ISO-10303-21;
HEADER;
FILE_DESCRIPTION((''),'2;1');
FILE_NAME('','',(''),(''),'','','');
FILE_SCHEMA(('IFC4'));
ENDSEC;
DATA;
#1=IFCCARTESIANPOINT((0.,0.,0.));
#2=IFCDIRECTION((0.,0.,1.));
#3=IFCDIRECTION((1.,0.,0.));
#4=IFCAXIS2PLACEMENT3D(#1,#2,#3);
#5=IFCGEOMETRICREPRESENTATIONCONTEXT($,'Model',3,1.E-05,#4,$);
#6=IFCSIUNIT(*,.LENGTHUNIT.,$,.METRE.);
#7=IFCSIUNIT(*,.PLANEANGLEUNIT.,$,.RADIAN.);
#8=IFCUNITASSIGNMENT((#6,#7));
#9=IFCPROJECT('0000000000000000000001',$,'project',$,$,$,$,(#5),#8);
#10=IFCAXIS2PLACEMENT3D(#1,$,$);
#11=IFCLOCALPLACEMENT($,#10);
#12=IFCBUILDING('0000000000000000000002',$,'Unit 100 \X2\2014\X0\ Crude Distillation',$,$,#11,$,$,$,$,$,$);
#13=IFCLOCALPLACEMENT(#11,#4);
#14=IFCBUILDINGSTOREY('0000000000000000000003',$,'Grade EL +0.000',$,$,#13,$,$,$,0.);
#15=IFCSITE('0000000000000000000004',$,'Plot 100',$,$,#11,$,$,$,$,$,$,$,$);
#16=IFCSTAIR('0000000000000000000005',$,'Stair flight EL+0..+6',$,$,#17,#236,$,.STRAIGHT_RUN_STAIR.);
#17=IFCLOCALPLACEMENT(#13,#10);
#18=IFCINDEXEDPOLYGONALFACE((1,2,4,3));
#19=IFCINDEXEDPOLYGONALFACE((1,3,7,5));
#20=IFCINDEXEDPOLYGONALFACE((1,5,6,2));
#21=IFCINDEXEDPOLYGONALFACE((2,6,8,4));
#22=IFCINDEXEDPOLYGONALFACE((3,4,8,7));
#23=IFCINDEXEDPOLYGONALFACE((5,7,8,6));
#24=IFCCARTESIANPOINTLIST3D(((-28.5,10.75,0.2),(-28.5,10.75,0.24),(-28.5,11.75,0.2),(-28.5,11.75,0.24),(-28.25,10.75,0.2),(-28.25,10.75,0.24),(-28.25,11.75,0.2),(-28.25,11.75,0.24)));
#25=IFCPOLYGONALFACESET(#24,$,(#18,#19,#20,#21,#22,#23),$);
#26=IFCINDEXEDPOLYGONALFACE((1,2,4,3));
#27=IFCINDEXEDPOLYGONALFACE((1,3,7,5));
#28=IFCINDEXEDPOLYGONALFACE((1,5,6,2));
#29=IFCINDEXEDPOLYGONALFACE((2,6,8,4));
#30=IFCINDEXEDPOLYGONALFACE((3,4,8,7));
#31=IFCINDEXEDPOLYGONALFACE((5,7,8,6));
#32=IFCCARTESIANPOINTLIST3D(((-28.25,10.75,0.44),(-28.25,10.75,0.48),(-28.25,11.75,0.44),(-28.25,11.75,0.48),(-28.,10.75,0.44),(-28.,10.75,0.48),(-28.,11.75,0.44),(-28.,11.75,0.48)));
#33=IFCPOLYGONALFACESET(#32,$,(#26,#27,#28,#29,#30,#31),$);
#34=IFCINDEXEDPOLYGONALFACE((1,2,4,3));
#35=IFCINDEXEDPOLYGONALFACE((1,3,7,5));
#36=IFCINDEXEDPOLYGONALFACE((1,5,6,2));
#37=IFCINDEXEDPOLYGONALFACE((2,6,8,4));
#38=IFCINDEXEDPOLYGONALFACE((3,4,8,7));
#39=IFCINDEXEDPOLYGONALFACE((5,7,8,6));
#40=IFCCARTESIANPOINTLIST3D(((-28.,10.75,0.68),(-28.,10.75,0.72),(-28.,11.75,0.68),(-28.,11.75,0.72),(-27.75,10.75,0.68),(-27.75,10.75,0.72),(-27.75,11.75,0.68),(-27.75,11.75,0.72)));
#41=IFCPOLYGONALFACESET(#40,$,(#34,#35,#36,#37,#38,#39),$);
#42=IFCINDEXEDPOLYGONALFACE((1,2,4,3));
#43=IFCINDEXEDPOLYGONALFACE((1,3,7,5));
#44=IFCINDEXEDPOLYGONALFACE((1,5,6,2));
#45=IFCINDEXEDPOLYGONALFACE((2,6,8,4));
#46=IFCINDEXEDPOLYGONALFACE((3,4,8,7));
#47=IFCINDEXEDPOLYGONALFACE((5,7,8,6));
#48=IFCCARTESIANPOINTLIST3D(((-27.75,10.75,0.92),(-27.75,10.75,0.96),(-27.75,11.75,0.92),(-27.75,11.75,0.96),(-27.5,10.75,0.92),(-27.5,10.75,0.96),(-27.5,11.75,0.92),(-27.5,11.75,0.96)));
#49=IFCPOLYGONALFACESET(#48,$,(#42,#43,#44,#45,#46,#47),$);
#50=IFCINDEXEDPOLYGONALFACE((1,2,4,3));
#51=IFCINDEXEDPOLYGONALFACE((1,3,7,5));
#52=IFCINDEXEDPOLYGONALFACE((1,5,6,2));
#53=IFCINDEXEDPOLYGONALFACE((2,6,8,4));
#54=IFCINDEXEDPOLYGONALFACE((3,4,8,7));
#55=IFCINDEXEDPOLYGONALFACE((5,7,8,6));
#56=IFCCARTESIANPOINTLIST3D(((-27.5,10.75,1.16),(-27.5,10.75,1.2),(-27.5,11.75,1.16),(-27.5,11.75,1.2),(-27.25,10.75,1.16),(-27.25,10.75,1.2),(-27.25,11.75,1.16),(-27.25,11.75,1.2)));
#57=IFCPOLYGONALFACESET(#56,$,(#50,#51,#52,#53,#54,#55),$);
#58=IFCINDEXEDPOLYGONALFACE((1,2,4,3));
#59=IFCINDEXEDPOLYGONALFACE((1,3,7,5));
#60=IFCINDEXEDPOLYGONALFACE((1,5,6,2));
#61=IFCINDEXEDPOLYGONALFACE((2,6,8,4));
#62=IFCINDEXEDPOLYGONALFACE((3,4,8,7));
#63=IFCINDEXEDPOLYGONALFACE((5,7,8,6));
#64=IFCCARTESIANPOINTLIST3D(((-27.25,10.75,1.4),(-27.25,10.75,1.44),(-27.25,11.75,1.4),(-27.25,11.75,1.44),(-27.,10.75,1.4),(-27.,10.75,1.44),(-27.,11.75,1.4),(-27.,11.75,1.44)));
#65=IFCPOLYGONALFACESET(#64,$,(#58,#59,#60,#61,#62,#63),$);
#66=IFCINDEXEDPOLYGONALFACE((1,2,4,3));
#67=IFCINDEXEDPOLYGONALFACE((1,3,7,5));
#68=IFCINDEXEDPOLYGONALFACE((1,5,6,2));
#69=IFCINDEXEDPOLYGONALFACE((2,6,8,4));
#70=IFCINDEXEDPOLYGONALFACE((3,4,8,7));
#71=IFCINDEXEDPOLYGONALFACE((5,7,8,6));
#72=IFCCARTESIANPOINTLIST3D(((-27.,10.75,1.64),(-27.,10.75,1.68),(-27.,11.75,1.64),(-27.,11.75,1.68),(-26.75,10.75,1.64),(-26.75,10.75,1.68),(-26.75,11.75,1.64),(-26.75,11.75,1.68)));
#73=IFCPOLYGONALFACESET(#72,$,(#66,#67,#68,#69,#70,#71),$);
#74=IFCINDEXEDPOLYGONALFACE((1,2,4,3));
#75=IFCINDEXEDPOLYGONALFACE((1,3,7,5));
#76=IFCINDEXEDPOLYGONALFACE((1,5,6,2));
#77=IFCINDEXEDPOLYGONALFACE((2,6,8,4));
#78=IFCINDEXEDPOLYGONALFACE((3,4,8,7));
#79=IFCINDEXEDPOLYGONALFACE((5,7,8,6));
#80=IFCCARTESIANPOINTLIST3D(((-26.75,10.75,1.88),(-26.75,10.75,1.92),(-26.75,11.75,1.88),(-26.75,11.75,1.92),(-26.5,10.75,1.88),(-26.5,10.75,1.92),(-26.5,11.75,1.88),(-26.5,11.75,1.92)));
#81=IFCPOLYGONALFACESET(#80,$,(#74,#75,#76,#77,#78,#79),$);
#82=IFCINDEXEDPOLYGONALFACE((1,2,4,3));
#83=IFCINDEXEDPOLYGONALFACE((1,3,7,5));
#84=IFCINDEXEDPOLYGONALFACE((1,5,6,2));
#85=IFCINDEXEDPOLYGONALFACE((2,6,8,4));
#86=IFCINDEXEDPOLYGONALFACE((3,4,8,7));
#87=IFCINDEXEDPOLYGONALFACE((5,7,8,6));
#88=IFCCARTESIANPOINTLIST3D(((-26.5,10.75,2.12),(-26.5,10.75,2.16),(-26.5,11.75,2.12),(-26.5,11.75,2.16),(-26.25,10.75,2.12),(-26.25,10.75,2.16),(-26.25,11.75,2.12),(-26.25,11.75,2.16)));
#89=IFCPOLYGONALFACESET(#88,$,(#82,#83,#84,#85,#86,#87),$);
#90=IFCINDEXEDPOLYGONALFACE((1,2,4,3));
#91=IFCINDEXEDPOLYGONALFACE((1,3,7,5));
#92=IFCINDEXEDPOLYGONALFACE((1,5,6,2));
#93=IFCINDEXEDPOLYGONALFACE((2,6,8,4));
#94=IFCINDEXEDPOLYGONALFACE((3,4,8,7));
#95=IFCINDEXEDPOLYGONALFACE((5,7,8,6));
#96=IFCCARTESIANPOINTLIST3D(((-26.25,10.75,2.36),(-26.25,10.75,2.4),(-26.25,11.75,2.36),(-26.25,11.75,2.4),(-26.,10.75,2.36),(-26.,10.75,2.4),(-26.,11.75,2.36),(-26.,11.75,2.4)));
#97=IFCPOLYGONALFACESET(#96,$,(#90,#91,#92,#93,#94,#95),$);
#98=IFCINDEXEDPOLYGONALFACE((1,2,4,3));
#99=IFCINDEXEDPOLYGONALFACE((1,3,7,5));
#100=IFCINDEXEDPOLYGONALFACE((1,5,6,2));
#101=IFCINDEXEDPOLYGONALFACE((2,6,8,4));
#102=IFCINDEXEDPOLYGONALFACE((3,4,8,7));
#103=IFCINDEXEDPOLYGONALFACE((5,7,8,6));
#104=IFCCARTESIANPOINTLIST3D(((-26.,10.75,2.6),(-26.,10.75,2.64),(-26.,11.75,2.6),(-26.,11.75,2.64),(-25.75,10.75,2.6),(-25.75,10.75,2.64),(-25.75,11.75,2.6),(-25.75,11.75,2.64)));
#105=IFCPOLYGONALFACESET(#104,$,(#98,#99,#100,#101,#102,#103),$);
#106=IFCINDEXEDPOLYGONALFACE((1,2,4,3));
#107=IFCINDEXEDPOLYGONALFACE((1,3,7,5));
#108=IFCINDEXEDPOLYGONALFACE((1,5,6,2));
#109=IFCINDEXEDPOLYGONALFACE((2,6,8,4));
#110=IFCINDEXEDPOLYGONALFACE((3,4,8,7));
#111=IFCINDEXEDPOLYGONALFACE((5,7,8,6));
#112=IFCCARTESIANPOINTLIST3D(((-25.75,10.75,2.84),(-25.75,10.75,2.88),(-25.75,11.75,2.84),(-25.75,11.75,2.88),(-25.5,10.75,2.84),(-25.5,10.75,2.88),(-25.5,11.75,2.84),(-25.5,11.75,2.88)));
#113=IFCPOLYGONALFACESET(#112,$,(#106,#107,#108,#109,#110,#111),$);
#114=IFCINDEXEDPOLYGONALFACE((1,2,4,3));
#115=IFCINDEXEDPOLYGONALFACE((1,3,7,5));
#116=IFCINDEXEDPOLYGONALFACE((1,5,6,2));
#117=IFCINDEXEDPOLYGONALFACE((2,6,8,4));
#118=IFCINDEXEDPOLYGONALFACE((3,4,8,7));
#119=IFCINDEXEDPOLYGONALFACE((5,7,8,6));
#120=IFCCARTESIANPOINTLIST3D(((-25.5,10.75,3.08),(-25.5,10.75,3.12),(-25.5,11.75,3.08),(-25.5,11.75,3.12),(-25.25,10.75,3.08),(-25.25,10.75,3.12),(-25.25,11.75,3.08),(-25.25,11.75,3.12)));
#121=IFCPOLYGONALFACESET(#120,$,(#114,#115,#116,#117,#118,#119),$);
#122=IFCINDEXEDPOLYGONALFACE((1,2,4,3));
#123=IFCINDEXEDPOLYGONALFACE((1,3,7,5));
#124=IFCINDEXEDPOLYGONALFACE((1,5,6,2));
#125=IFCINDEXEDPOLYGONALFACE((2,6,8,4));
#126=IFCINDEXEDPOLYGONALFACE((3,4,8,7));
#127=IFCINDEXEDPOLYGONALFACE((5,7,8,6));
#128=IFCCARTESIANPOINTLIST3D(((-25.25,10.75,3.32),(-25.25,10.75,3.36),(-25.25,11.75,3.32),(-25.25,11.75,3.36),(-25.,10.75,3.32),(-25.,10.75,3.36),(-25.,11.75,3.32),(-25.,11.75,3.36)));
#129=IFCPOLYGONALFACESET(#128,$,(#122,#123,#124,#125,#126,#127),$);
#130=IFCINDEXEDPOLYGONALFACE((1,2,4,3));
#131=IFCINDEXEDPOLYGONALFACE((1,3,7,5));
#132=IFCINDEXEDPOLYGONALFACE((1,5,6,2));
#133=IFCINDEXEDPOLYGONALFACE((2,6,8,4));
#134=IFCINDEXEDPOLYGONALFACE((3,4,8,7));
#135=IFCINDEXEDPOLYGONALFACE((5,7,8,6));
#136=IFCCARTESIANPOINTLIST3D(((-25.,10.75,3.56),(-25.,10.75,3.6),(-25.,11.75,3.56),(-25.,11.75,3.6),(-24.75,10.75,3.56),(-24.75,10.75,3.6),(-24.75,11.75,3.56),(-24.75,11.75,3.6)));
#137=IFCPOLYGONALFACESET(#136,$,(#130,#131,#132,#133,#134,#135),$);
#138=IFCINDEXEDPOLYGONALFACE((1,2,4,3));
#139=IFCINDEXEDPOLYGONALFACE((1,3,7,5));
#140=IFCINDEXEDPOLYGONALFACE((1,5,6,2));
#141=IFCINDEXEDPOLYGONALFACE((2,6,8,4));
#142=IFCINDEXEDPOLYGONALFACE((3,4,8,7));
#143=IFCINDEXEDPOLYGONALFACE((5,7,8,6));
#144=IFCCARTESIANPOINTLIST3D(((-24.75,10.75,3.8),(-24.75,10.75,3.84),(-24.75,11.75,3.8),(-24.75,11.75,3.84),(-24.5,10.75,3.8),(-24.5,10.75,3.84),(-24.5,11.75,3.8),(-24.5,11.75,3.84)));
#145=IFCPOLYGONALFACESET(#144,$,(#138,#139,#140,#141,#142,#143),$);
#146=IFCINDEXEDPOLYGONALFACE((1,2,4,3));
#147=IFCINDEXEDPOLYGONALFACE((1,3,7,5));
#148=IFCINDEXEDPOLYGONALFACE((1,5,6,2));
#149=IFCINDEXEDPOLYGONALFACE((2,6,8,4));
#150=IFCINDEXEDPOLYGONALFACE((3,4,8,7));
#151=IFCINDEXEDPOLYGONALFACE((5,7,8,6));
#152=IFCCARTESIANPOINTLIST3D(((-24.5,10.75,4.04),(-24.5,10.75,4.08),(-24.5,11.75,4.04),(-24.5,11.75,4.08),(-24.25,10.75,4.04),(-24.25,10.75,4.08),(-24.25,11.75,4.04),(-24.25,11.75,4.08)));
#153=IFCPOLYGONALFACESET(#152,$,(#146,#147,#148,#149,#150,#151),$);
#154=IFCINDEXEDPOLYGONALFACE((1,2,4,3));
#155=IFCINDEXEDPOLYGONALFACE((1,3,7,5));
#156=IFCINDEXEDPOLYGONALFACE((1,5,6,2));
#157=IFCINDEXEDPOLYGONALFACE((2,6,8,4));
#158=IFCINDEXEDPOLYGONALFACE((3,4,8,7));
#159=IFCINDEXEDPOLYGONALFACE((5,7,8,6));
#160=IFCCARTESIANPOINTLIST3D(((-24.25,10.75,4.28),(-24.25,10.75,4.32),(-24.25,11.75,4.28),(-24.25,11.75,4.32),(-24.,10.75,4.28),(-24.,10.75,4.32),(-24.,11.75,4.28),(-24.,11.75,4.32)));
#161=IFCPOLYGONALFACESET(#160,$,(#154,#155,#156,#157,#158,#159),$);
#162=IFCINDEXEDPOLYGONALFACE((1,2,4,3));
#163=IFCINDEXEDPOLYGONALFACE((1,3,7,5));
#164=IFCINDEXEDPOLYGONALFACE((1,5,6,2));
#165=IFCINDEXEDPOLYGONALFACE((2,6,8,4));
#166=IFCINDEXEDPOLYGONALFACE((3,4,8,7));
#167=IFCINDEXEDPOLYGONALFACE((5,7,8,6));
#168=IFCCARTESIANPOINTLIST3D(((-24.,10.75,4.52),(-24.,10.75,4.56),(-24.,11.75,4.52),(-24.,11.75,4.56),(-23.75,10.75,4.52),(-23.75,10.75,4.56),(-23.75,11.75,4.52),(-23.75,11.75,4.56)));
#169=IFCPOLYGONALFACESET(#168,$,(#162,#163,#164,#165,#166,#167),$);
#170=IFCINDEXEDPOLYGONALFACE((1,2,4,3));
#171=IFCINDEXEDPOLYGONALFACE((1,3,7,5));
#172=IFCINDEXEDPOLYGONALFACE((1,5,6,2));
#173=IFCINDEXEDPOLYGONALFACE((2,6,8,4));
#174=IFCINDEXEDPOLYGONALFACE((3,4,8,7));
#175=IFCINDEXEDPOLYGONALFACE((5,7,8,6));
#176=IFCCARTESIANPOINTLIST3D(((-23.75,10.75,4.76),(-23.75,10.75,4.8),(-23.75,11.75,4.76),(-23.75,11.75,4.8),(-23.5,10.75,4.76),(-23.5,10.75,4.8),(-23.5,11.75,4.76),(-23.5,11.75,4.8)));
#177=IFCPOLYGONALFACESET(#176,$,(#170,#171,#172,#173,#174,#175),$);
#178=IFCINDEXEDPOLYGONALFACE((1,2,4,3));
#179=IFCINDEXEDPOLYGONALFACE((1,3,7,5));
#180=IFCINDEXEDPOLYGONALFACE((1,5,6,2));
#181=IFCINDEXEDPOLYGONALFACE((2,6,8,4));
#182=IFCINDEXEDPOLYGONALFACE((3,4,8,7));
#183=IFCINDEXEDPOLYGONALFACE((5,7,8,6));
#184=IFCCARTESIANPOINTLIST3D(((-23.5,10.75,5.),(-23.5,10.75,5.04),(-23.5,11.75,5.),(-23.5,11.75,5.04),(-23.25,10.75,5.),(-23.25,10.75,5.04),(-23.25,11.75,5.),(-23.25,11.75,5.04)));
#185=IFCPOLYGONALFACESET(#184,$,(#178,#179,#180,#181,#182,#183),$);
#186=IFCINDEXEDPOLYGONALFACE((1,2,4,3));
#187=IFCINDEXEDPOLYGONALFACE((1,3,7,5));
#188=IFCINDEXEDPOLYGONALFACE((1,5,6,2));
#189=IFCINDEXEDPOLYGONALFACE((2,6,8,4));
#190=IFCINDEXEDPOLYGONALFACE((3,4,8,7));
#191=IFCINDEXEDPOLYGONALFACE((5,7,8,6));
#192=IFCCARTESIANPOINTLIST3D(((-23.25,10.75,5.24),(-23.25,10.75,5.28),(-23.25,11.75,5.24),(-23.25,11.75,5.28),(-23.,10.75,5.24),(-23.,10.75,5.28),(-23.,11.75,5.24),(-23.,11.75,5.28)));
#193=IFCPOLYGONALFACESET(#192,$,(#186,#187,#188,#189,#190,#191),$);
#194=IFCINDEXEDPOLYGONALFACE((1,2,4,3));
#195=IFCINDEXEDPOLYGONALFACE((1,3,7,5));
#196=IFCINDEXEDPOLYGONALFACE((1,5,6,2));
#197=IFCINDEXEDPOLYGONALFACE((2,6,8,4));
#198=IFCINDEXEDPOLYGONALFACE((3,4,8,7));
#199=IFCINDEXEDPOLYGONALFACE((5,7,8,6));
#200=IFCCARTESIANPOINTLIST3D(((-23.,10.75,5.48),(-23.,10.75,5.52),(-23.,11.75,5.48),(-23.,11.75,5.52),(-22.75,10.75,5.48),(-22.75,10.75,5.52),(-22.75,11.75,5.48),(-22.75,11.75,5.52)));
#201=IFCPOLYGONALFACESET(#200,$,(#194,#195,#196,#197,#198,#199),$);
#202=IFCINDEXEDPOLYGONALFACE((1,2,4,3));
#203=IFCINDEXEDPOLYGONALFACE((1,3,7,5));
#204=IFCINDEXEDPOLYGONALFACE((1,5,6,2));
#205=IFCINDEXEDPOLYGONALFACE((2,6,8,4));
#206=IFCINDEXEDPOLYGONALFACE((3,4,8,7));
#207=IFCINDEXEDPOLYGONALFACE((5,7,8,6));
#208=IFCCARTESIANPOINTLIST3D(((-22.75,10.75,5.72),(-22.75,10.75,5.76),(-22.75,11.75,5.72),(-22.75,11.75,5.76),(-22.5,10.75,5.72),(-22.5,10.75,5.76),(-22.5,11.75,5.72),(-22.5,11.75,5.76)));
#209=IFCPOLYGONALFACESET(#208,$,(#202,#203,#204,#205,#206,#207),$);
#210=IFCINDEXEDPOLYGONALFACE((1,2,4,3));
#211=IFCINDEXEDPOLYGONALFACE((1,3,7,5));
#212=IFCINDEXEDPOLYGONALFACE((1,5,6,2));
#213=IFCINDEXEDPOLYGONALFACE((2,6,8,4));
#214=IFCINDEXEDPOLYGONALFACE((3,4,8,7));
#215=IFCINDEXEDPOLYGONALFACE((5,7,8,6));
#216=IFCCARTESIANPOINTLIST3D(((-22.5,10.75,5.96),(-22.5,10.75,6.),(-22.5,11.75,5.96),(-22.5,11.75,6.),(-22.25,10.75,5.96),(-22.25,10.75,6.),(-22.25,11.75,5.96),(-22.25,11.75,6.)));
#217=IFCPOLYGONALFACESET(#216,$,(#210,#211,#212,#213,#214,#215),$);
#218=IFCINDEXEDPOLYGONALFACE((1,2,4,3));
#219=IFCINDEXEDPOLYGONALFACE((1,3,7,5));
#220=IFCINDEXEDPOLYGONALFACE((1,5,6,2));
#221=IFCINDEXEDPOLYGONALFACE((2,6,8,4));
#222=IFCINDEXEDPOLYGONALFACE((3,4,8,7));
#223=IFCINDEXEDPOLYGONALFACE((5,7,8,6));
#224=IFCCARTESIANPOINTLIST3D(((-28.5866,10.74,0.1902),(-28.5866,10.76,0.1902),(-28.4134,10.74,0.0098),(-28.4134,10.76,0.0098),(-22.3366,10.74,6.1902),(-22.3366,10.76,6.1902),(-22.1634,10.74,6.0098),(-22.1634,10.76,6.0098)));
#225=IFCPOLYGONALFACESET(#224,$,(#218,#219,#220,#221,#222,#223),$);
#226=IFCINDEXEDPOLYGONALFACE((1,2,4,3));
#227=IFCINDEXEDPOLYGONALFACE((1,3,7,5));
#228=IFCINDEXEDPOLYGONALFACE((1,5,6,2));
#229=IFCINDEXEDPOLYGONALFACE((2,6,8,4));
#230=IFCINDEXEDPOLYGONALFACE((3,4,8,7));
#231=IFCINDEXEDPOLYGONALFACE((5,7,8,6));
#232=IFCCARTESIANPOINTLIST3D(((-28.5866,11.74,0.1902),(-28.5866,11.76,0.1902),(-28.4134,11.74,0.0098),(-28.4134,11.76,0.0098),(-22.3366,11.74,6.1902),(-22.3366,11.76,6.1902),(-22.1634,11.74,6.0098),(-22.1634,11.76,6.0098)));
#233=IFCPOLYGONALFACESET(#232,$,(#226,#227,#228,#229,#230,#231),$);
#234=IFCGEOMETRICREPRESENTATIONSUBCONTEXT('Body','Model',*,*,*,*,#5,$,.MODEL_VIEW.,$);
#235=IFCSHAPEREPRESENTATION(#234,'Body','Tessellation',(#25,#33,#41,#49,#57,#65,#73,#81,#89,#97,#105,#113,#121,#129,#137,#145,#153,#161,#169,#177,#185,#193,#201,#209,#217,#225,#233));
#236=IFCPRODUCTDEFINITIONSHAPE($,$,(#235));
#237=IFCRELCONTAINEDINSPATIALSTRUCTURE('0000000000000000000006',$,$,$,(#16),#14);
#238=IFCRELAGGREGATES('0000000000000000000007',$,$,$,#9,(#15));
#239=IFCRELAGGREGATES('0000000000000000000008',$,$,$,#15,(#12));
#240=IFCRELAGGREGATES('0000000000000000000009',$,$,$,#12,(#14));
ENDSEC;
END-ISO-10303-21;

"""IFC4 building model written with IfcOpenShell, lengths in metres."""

from ifc_helpers import new_model, si_unit, frame, origin, origin_with_axes, origin_2d, place, context, subcontext, project, spatial, rectangle, extrude, element, save


model = new_model("IFC4")

# Units and contexts
model_context = context("Model", 3, precision=1e-05, world=origin_with_axes())
body_context = subcontext(model_context, "Body", "Model", "MODEL_VIEW")
ifc_project = project(units=[si_unit("LENGTHUNIT", "METRE"), si_unit("PLANEANGLEUNIT", "RADIAN")], contexts=[model_context])

# Site, building, storey
placement = place(None, origin())
site = spatial("IfcSite", under=ifc_project, at=placement, Name="Plot 100")
building = spatial("IfcBuilding", under=site, at=placement, Name="Unit 100 — Crude Distillation")
storey_placement = place(placement, origin_with_axes())
storey = spatial("IfcBuildingStorey", under=building, at=storey_placement, Name="Grade EL +0.000", Elevation=0.0)

# Stair
stair_placement = place(storey_placement, origin_with_axes())
element("IfcStair", 1, at=stair_placement, inside=storey, Name="Stair flight EL+0..+6", PredefinedType="STRAIGHT_RUN_STAIR", context=body_context, shape_type="SweptSolid", body=[
    extrude(rectangle(XDim=0.25, YDim=1.0, at=origin_2d()), frame((-28.375, 11.25, 0.2), z_axis=(0.0, 0.0, 1.0), x_axis=(1.0, 0.0, 0.0)), (0.0, 0.0, 1.0), 0.04),
    extrude(rectangle(XDim=0.25, YDim=1.0, at=origin_2d()), frame((-28.125, 11.25, 0.44), z_axis=(0.0, 0.0, 1.0), x_axis=(1.0, 0.0, 0.0)), (0.0, 0.0, 1.0), 0.04),
    extrude(rectangle(XDim=0.25, YDim=1.0, at=origin_2d()), frame((-27.875, 11.25, 0.68), z_axis=(0.0, 0.0, 1.0), x_axis=(1.0, 0.0, 0.0)), (0.0, 0.0, 1.0), 0.04),
    extrude(rectangle(XDim=0.25, YDim=1.0, at=origin_2d()), frame((-27.625, 11.25, 0.92), z_axis=(0.0, 0.0, 1.0), x_axis=(1.0, 0.0, 0.0)), (0.0, 0.0, 1.0), 0.04),
    extrude(rectangle(XDim=0.25, YDim=1.0, at=origin_2d()), frame((-27.375, 11.25, 1.16), z_axis=(0.0, 0.0, 1.0), x_axis=(1.0, 0.0, 0.0)), (0.0, 0.0, 1.0), 0.04),
    extrude(rectangle(XDim=0.25, YDim=1.0, at=origin_2d()), frame((-27.125, 11.25, 1.4), z_axis=(0.0, 0.0, 1.0), x_axis=(1.0, 0.0, 0.0)), (0.0, 0.0, 1.0), 0.04),
    extrude(rectangle(XDim=0.25, YDim=1.0, at=origin_2d()), frame((-26.875, 11.25, 1.64), z_axis=(0.0, 0.0, 1.0), x_axis=(1.0, 0.0, 0.0)), (0.0, 0.0, 1.0), 0.04),
    extrude(rectangle(XDim=0.25, YDim=1.0, at=origin_2d()), frame((-26.625, 11.25, 1.88), z_axis=(0.0, 0.0, 1.0), x_axis=(1.0, 0.0, 0.0)), (0.0, 0.0, 1.0), 0.04),
    extrude(rectangle(XDim=0.25, YDim=1.0, at=origin_2d()), frame((-26.375, 11.25, 2.12), z_axis=(0.0, 0.0, 1.0), x_axis=(1.0, 0.0, 0.0)), (0.0, 0.0, 1.0), 0.04),
    extrude(rectangle(XDim=0.25, YDim=1.0, at=origin_2d()), frame((-26.125, 11.25, 2.36), z_axis=(0.0, 0.0, 1.0), x_axis=(1.0, 0.0, 0.0)), (0.0, 0.0, 1.0), 0.04),
    extrude(rectangle(XDim=0.25, YDim=1.0, at=origin_2d()), frame((-25.875, 11.25, 2.6), z_axis=(0.0, 0.0, 1.0), x_axis=(1.0, 0.0, 0.0)), (0.0, 0.0, 1.0), 0.04),
    extrude(rectangle(XDim=0.25, YDim=1.0, at=origin_2d()), frame((-25.625, 11.25, 2.84), z_axis=(0.0, 0.0, 1.0), x_axis=(1.0, 0.0, 0.0)), (0.0, 0.0, 1.0), 0.04),
    extrude(rectangle(XDim=0.25, YDim=1.0, at=origin_2d()), frame((-25.375, 11.25, 3.08), z_axis=(0.0, 0.0, 1.0), x_axis=(1.0, 0.0, 0.0)), (0.0, 0.0, 1.0), 0.04),
    extrude(rectangle(XDim=0.25, YDim=1.0, at=origin_2d()), frame((-25.125, 11.25, 3.32), z_axis=(0.0, 0.0, 1.0), x_axis=(1.0, 0.0, 0.0)), (0.0, 0.0, 1.0), 0.04),
    extrude(rectangle(XDim=0.25, YDim=1.0, at=origin_2d()), frame((-24.875, 11.25, 3.56), z_axis=(0.0, 0.0, 1.0), x_axis=(1.0, 0.0, 0.0)), (0.0, 0.0, 1.0), 0.04),
    extrude(rectangle(XDim=0.25, YDim=1.0, at=origin_2d()), frame((-24.625, 11.25, 3.8), z_axis=(0.0, 0.0, 1.0), x_axis=(1.0, 0.0, 0.0)), (0.0, 0.0, 1.0), 0.04),
    extrude(rectangle(XDim=0.25, YDim=1.0, at=origin_2d()), frame((-24.375, 11.25, 4.04), z_axis=(0.0, 0.0, 1.0), x_axis=(1.0, 0.0, 0.0)), (0.0, 0.0, 1.0), 0.04),
    extrude(rectangle(XDim=0.25, YDim=1.0, at=origin_2d()), frame((-24.125, 11.25, 4.28), z_axis=(0.0, 0.0, 1.0), x_axis=(1.0, 0.0, 0.0)), (0.0, 0.0, 1.0), 0.04),
    extrude(rectangle(XDim=0.25, YDim=1.0, at=origin_2d()), frame((-23.875, 11.25, 4.52), z_axis=(0.0, 0.0, 1.0), x_axis=(1.0, 0.0, 0.0)), (0.0, 0.0, 1.0), 0.04),
    extrude(rectangle(XDim=0.25, YDim=1.0, at=origin_2d()), frame((-23.625, 11.25, 4.76), z_axis=(0.0, 0.0, 1.0), x_axis=(1.0, 0.0, 0.0)), (0.0, 0.0, 1.0), 0.04),
    extrude(rectangle(XDim=0.25, YDim=1.0, at=origin_2d()), frame((-23.375, 11.25, 5.0), z_axis=(0.0, 0.0, 1.0), x_axis=(1.0, 0.0, 0.0)), (0.0, 0.0, 1.0), 0.04),
    extrude(rectangle(XDim=0.25, YDim=1.0, at=origin_2d()), frame((-23.125, 11.25, 5.24), z_axis=(0.0, 0.0, 1.0), x_axis=(1.0, 0.0, 0.0)), (0.0, 0.0, 1.0), 0.04),
    extrude(rectangle(XDim=0.25, YDim=1.0, at=origin_2d()), frame((-22.875, 11.25, 5.48), z_axis=(0.0, 0.0, 1.0), x_axis=(1.0, 0.0, 0.0)), (0.0, 0.0, 1.0), 0.04),
    extrude(rectangle(XDim=0.25, YDim=1.0, at=origin_2d()), frame((-22.625, 11.25, 5.72), z_axis=(0.0, 0.0, 1.0), x_axis=(1.0, 0.0, 0.0)), (0.0, 0.0, 1.0), 0.04),
    extrude(rectangle(XDim=0.25, YDim=1.0, at=origin_2d()), frame((-22.375, 11.25, 5.96), z_axis=(0.0, 0.0, 1.0), x_axis=(1.0, 0.0, 0.0)), (0.0, 0.0, 1.0), 0.04),
    extrude(rectangle(XDim=0.02, YDim=0.25, at=origin_2d()), frame((-28.5, 10.75, 0.1), z_axis=(0.721387, 0.0, 0.692532), x_axis=(0.0, 1.0, 0.0)), (0.0, 0.0, 1.0), 8.6639),
    extrude(rectangle(XDim=0.02, YDim=0.25, at=origin_2d()), frame((-28.5, 11.75, 0.1), z_axis=(0.721387, 0.0, 0.692532), x_axis=(0.0, 1.0, 0.0)), (0.0, 0.0, 1.0), 8.6639),
])

save(model, "model.ifc")
